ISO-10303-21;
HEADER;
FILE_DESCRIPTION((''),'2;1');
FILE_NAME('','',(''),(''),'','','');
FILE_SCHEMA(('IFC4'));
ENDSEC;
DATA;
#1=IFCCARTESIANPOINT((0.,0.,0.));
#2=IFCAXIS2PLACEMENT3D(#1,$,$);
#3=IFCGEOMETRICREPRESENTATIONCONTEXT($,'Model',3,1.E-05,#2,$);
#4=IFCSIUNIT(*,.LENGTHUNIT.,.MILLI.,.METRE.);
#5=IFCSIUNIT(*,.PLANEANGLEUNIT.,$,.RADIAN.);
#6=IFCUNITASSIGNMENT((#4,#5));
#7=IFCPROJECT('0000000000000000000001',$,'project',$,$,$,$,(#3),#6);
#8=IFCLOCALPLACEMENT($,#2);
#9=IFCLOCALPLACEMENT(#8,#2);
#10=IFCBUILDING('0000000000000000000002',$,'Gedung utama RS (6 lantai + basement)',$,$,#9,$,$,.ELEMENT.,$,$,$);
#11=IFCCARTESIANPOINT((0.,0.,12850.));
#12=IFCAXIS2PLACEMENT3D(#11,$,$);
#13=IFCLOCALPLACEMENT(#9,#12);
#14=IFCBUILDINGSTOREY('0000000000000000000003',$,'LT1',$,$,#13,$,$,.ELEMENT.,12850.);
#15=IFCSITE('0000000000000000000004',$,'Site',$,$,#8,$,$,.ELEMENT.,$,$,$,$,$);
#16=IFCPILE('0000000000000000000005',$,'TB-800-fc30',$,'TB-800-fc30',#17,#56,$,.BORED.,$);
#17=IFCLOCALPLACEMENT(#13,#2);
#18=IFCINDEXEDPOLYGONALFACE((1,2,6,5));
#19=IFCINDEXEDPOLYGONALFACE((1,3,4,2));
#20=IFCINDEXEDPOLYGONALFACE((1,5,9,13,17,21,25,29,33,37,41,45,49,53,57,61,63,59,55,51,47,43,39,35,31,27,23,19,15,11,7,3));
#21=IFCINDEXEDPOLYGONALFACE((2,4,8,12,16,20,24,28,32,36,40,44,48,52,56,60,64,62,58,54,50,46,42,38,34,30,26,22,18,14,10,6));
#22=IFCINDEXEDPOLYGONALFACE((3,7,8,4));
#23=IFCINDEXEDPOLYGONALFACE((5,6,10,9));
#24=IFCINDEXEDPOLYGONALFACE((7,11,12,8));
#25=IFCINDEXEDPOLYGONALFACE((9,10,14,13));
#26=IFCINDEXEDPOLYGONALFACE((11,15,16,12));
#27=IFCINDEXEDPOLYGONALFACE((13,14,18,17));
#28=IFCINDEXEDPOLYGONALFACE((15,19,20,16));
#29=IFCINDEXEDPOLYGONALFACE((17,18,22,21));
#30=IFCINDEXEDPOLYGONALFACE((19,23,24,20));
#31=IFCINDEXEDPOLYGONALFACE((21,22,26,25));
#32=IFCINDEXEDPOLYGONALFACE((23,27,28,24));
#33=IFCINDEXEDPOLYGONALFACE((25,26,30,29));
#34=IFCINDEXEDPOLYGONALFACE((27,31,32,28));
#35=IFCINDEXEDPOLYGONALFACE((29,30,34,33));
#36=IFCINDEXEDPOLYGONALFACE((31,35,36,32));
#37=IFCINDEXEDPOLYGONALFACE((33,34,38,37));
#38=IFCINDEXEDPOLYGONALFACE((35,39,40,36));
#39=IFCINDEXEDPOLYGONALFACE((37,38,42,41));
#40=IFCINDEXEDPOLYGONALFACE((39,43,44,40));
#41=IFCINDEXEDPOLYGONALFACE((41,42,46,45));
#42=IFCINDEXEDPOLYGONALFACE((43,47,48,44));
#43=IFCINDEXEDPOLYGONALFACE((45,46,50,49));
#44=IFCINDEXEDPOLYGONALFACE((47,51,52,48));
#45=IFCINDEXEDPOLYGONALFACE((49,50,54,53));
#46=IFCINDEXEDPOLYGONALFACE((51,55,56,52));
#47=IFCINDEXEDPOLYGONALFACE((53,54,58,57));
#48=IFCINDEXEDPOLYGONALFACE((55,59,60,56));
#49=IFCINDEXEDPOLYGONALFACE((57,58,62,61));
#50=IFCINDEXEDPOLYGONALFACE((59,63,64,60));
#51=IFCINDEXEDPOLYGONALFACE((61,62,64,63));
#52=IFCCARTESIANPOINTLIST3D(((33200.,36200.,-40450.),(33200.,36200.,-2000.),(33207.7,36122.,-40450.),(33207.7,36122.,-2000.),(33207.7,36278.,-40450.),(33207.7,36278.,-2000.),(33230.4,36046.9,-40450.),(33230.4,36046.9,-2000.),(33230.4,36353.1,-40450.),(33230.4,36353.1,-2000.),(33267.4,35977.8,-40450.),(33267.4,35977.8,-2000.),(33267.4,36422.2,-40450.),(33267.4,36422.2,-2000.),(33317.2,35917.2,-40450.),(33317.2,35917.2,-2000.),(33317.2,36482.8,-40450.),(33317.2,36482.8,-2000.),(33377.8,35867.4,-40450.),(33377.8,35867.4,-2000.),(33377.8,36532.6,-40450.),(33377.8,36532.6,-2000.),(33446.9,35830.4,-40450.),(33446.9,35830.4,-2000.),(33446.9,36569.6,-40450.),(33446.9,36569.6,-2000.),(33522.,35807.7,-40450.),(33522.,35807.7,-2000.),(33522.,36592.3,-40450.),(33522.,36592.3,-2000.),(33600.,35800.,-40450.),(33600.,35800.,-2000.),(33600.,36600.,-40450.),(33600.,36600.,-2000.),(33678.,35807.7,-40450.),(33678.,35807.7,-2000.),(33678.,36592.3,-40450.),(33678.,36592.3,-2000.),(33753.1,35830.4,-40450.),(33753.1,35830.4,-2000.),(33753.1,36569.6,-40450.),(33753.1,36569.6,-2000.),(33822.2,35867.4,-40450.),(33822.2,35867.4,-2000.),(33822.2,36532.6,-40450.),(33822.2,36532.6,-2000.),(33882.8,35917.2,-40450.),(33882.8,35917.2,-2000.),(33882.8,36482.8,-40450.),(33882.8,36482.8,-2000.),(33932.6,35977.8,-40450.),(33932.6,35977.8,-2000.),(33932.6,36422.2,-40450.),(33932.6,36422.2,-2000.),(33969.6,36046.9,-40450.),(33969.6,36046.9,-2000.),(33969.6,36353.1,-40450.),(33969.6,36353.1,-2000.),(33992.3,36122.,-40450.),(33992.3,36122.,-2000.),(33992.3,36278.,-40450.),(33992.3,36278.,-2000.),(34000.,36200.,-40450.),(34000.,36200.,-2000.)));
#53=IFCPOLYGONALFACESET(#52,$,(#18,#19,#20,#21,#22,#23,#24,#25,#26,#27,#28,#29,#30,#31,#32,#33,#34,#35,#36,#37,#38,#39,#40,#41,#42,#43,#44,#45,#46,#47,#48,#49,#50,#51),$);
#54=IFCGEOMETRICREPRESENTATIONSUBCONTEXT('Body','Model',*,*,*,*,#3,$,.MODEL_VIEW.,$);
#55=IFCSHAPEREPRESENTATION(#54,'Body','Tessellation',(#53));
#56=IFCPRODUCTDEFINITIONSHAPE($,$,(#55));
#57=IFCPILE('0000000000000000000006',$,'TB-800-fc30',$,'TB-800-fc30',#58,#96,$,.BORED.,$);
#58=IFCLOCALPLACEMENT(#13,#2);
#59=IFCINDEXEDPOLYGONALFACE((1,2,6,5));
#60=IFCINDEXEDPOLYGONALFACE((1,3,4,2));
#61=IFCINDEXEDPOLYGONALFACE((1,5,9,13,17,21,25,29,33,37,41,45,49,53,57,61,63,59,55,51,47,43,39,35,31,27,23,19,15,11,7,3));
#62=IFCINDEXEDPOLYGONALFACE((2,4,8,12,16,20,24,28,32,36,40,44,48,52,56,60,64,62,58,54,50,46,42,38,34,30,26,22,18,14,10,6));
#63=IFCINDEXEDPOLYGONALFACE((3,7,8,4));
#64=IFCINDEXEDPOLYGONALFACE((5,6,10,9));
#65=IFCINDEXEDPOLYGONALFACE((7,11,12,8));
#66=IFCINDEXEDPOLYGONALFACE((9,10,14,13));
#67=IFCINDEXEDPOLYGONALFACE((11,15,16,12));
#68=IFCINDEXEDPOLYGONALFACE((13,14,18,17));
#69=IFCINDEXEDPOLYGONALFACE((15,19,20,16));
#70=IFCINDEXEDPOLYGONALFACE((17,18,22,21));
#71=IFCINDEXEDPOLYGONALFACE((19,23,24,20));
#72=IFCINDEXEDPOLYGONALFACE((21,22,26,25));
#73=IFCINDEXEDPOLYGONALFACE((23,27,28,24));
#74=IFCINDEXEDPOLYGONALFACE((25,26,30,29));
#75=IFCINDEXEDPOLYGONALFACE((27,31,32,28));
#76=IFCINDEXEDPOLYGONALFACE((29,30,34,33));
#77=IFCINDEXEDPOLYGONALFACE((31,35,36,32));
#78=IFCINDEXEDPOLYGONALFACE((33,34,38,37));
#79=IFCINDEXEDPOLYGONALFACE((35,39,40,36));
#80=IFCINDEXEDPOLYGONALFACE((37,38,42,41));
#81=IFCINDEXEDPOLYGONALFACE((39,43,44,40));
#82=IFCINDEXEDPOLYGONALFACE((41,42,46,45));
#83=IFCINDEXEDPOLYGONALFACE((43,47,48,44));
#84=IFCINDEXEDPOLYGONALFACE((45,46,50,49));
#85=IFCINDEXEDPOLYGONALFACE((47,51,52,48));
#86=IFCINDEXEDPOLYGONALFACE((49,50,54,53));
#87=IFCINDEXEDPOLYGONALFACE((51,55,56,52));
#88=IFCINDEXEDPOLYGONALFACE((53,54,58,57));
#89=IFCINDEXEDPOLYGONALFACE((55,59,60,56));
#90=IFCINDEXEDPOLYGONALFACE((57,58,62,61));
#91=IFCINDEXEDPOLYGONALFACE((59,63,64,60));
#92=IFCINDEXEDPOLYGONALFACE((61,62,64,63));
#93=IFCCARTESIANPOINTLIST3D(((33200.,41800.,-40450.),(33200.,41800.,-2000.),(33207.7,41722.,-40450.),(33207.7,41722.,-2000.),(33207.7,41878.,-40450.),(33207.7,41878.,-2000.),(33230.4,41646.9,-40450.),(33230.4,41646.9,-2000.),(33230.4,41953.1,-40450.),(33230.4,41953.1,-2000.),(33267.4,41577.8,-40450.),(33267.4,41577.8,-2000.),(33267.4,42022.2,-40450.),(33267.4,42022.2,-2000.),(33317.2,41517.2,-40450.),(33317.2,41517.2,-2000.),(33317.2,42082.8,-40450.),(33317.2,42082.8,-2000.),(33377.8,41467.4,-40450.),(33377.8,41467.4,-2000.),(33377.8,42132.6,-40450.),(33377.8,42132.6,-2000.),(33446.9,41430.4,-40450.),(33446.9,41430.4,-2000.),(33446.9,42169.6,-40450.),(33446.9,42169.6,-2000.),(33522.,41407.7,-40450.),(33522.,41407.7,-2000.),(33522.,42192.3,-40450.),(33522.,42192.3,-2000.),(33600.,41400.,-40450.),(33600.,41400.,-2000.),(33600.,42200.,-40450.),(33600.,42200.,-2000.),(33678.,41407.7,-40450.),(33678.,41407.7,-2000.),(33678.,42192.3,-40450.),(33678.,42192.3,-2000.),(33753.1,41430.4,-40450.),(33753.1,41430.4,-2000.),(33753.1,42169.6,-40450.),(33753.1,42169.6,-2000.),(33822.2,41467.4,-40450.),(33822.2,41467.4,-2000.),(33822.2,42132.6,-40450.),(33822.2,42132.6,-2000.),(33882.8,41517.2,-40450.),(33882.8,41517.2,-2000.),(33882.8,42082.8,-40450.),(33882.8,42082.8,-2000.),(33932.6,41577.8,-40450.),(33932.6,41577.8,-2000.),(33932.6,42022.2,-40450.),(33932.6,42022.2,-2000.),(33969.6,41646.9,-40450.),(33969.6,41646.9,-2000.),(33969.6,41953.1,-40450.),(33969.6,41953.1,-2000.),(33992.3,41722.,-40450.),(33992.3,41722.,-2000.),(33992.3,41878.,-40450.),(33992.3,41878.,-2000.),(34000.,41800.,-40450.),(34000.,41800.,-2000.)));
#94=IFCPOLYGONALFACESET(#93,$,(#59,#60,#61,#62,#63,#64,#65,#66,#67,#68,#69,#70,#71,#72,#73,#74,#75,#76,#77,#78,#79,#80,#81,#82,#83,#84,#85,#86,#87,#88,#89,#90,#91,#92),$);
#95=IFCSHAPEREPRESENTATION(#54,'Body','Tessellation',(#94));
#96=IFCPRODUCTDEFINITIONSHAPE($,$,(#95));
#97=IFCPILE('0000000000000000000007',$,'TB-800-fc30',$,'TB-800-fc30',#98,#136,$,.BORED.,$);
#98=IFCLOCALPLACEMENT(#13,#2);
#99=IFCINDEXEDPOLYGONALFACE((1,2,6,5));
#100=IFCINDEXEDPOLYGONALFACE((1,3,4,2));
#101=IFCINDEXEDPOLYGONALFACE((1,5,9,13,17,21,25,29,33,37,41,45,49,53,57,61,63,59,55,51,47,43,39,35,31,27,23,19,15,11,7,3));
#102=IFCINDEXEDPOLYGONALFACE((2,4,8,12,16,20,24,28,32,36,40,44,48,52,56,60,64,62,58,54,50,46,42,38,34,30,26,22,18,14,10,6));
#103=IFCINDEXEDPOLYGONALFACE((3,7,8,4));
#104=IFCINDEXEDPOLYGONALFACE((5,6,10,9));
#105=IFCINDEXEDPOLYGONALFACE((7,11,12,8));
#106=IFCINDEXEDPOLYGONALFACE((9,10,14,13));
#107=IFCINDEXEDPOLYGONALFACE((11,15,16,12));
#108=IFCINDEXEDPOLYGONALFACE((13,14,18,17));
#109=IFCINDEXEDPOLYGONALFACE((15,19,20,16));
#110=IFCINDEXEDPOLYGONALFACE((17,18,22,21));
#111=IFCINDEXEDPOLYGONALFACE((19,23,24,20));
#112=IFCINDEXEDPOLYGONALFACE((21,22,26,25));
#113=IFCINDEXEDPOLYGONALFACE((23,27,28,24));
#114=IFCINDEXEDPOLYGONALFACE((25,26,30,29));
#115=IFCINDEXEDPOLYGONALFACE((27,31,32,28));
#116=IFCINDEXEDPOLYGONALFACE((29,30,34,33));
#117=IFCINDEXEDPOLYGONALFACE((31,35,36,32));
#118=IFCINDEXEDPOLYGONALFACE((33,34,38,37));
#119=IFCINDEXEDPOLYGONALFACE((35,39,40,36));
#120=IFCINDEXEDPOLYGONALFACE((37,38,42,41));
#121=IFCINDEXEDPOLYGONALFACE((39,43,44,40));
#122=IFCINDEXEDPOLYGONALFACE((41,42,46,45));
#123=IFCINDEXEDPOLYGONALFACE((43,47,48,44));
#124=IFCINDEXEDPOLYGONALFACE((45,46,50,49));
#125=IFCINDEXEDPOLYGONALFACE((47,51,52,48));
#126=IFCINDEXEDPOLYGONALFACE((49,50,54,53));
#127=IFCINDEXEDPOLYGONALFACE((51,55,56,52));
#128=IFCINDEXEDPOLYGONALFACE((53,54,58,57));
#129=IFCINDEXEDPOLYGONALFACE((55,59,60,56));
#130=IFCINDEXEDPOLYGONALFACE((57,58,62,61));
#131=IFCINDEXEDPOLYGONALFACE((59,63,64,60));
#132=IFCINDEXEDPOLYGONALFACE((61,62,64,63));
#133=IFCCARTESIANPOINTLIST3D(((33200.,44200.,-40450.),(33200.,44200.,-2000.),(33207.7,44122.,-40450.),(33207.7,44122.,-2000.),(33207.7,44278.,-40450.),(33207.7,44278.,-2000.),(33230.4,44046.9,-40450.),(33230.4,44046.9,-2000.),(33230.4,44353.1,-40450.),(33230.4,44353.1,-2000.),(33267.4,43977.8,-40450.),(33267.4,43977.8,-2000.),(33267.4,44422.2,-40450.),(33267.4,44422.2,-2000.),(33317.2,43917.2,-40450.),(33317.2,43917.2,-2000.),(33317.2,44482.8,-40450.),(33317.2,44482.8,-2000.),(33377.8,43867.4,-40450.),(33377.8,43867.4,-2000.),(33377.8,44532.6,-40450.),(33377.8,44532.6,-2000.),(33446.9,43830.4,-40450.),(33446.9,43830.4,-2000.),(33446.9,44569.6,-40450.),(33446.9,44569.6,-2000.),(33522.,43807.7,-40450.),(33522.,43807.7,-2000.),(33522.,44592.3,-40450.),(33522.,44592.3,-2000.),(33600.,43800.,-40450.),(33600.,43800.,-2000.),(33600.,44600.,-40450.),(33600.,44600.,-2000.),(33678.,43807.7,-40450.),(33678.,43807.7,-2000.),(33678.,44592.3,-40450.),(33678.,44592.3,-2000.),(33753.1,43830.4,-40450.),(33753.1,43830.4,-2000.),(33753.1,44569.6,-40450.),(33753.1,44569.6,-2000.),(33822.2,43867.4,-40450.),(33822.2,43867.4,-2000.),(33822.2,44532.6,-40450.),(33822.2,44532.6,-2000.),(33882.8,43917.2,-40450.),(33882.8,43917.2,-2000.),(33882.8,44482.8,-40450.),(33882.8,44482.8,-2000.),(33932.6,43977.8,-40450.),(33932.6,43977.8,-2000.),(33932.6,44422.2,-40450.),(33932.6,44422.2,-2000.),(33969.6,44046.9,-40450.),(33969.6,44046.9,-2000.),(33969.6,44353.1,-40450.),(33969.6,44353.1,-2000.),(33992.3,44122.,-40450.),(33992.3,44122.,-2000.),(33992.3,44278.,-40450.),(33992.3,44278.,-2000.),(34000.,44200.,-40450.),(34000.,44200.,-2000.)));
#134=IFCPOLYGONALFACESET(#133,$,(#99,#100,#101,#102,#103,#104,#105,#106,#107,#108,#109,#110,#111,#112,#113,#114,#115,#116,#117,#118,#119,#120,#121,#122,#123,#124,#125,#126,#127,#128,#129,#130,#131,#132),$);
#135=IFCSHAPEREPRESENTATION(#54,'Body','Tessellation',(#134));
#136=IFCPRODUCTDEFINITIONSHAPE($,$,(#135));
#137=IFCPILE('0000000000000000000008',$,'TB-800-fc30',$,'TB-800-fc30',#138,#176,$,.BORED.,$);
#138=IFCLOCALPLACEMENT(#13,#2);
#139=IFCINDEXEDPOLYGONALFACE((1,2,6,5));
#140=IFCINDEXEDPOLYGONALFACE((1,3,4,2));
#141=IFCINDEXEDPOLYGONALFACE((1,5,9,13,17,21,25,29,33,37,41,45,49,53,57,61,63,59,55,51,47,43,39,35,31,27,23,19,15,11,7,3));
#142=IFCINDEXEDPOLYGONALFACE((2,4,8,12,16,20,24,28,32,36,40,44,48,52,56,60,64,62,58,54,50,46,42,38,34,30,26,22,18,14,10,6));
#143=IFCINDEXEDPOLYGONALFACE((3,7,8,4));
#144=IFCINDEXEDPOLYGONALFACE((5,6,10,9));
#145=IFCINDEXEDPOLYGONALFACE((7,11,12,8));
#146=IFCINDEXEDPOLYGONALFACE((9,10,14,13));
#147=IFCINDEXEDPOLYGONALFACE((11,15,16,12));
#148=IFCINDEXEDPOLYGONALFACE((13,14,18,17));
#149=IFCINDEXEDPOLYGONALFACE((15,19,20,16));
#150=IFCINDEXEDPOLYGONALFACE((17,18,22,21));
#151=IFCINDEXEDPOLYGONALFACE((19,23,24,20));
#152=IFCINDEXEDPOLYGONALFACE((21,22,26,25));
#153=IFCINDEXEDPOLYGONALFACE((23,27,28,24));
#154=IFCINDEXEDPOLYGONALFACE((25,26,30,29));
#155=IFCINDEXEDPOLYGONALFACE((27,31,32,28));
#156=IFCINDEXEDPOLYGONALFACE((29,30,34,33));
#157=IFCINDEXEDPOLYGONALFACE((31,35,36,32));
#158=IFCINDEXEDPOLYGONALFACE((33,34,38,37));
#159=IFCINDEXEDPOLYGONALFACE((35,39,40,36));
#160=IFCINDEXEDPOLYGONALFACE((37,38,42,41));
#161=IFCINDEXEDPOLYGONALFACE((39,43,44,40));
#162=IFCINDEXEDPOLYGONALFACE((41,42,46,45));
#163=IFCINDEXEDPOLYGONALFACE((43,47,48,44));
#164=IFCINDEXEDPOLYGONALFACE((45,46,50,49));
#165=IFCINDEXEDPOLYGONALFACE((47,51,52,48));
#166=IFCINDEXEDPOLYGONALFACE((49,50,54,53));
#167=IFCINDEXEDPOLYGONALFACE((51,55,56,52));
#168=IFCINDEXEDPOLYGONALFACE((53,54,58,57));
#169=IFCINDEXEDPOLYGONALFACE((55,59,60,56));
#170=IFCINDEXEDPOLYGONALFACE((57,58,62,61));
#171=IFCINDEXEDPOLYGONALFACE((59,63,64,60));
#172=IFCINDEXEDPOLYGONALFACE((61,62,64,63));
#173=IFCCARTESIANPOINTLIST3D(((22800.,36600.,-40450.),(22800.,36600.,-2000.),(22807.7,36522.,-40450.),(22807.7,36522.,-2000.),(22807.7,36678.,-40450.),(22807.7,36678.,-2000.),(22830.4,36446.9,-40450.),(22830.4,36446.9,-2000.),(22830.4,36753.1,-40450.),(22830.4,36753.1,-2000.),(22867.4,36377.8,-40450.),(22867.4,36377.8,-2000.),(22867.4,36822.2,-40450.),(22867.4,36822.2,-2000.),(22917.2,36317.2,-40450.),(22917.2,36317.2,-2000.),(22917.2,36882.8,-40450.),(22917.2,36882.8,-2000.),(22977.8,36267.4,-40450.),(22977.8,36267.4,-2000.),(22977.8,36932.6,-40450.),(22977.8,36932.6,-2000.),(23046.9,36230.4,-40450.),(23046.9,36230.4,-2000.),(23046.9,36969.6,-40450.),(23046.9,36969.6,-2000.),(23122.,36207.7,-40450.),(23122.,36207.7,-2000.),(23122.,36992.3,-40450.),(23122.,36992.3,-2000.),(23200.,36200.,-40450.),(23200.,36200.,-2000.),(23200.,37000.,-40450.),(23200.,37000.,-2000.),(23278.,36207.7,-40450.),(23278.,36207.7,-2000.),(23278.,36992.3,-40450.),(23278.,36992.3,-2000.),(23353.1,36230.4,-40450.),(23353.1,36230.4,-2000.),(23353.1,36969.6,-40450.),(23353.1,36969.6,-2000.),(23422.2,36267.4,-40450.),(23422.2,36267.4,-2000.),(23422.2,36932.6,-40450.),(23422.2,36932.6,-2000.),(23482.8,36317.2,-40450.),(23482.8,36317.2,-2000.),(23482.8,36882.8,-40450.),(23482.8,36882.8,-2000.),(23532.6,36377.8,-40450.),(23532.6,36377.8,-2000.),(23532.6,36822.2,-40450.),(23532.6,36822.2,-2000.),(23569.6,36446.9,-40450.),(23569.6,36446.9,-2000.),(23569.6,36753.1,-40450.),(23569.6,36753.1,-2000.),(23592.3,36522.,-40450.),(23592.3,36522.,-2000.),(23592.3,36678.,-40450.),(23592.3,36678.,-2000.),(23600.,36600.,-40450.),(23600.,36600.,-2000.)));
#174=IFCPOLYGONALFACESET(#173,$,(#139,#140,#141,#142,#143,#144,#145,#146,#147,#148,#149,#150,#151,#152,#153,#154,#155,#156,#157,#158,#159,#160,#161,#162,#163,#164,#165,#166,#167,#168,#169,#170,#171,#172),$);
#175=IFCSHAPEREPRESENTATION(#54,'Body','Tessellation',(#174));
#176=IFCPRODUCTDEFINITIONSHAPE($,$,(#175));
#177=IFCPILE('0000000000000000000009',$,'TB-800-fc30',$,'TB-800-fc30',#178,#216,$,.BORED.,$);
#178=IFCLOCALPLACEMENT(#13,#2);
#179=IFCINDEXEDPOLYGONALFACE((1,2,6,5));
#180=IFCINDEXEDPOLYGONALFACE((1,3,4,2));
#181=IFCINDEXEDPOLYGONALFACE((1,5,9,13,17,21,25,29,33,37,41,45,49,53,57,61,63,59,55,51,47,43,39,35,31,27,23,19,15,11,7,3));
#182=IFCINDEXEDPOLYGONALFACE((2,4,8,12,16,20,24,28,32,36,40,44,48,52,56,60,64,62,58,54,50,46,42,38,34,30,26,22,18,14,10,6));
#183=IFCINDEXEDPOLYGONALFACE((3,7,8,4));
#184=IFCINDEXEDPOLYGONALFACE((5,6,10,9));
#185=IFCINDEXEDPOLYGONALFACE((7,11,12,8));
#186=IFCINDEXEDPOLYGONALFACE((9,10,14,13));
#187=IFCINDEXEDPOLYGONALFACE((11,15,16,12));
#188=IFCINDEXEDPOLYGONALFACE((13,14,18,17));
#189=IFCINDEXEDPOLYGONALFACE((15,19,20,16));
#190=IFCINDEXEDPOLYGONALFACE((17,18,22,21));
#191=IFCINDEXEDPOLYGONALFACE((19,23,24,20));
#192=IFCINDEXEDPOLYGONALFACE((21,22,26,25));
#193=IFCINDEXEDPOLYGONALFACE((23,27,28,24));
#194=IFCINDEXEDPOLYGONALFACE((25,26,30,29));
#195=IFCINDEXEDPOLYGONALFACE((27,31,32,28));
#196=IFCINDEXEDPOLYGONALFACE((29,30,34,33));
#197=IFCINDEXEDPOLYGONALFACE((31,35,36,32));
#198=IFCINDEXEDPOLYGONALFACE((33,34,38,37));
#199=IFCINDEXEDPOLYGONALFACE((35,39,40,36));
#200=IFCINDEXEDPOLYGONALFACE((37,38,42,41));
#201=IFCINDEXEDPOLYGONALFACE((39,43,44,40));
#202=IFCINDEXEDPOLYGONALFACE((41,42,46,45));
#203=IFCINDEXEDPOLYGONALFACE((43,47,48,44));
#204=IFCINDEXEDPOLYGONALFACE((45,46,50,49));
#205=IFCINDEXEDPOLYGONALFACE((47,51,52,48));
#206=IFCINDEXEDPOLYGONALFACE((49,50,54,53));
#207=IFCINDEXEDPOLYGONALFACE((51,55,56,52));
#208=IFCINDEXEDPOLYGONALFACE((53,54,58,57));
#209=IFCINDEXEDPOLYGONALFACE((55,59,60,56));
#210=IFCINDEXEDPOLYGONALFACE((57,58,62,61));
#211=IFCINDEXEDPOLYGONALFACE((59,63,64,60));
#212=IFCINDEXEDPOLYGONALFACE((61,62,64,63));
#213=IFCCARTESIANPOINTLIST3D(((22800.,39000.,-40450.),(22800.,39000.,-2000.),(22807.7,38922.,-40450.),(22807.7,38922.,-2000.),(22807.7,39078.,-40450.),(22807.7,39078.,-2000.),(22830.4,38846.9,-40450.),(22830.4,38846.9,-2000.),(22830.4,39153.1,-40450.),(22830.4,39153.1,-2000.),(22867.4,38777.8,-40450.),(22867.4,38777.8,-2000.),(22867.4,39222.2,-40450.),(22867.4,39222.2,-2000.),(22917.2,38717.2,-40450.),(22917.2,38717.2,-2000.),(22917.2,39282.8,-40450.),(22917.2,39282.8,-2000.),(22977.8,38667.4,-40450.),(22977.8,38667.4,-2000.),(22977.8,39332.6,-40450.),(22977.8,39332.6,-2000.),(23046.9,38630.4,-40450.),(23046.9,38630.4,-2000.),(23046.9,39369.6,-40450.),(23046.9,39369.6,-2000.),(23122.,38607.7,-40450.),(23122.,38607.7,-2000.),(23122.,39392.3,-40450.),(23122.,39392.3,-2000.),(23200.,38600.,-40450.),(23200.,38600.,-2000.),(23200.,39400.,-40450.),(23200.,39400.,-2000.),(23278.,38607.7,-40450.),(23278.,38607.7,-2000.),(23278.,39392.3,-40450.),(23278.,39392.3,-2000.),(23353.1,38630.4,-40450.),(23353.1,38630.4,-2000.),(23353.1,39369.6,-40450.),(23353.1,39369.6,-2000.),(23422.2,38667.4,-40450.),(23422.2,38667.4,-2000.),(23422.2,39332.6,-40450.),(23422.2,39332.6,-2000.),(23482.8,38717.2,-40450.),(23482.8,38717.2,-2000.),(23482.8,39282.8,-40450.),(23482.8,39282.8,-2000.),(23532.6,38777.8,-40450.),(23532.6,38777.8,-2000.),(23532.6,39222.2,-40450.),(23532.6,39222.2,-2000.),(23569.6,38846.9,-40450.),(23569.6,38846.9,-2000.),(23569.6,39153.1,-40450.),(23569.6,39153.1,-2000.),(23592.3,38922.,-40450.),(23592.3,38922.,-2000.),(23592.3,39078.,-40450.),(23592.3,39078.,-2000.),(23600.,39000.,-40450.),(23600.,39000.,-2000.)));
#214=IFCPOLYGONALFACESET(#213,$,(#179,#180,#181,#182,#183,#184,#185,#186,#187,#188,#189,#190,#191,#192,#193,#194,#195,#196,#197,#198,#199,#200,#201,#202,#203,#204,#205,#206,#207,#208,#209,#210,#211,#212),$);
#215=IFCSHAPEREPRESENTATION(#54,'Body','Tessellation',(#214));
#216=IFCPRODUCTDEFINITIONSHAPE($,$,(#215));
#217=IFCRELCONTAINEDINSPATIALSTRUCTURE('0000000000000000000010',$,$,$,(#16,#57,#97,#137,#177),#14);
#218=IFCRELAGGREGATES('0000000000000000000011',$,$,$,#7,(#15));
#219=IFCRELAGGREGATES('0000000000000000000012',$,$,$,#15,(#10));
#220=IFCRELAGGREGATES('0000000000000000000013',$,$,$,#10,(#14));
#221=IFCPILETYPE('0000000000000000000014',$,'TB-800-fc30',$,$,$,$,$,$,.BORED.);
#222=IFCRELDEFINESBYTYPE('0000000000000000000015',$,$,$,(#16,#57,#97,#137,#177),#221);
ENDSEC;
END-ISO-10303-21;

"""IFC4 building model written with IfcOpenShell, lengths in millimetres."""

from ifc_helpers import new_model, si_unit, frame, origin, origin_2d, place, context, subcontext, project, spatial, circle, extrude, material_profile, profile_set, profile_usage, type_object, element, save


model = new_model("IFC4")

# Units and contexts
model_context = context("Model", 3, precision=1e-05, world=origin())
body_context = subcontext(model_context, "Body", "Model", "MODEL_VIEW")
ifc_project = project(units=[si_unit("LENGTHUNIT", "METRE", prefix="MILLI"), si_unit("PLANEANGLEUNIT", "RADIAN")], contexts=[model_context])

# Site, building, storey
site_placement = place(None, origin())
site = spatial("IfcSite", under=ifc_project, at=site_placement, Name="Site", CompositionType="ELEMENT")
building_placement = place(site_placement, origin())
building = spatial("IfcBuilding", under=site, at=building_placement, Name="Gedung utama RS (6 lantai + basement)", CompositionType="ELEMENT")
storey_placement = place(building_placement, frame((0.0, 0.0, 12850.0)))
storey = spatial("IfcBuildingStorey", under=building, at=storey_placement, Name="LT1", CompositionType="ELEMENT", Elevation=12850.0)

# Piles
ifc_material_profile_1 = material_profile(None, circle(Radius=400.0, at=origin_2d()), Name="TB-800-fc30")
ifc_profile_set_1 = profile_set([ifc_material_profile_1], Name="TB-800-fc30")
ifc_profile_usage_1 = profile_usage(ifc_profile_set_1, cardinal=5)
pile_type = type_object("IfcPileType", Name="TB-800-fc30", PredefinedType="BORED", material=ifc_profile_set_1)
for number, where, z_axis, x_axis, name in (
    (1, (33600.0, 36200.0, -40450.0), (0.0, 0.0, 1.0), (1.0, 0.0, 0.0), "TB-800-fc30"),
    (2, (33600.0, 41800.0, -40450.0), (0.0, 0.0, 1.0), (1.0, 0.0, 0.0), "TB-800-fc30"),
    (3, (33600.0, 44200.0, -40450.0), (0.0, 0.0, 1.0), (1.0, 0.0, 0.0), "TB-800-fc30"),
    (4, (23200.0, 36600.0, -40450.0), (0.0, 0.0, 1.0), (1.0, 0.0, 0.0), "TB-800-fc30"),
    (5, (23200.0, 39000.0, -40450.0), (0.0, 0.0, 1.0), (1.0, 0.0, 0.0), "TB-800-fc30"),
):
    element("IfcPile", number, at=place(storey_placement, frame(where, z_axis=z_axis, x_axis=x_axis)), inside=storey, type_object=pile_type, material=ifc_profile_usage_1, Name=name, ObjectType="TB-800-fc30", PredefinedType="BORED", context=body_context, shape_type="SweptSolid", body=[
        extrude(circle(Radius=400.0, at=origin_2d()), origin(), (0.0, 0.0, 1.0), 38450.0),
    ])

save(model, "model.ifc")
